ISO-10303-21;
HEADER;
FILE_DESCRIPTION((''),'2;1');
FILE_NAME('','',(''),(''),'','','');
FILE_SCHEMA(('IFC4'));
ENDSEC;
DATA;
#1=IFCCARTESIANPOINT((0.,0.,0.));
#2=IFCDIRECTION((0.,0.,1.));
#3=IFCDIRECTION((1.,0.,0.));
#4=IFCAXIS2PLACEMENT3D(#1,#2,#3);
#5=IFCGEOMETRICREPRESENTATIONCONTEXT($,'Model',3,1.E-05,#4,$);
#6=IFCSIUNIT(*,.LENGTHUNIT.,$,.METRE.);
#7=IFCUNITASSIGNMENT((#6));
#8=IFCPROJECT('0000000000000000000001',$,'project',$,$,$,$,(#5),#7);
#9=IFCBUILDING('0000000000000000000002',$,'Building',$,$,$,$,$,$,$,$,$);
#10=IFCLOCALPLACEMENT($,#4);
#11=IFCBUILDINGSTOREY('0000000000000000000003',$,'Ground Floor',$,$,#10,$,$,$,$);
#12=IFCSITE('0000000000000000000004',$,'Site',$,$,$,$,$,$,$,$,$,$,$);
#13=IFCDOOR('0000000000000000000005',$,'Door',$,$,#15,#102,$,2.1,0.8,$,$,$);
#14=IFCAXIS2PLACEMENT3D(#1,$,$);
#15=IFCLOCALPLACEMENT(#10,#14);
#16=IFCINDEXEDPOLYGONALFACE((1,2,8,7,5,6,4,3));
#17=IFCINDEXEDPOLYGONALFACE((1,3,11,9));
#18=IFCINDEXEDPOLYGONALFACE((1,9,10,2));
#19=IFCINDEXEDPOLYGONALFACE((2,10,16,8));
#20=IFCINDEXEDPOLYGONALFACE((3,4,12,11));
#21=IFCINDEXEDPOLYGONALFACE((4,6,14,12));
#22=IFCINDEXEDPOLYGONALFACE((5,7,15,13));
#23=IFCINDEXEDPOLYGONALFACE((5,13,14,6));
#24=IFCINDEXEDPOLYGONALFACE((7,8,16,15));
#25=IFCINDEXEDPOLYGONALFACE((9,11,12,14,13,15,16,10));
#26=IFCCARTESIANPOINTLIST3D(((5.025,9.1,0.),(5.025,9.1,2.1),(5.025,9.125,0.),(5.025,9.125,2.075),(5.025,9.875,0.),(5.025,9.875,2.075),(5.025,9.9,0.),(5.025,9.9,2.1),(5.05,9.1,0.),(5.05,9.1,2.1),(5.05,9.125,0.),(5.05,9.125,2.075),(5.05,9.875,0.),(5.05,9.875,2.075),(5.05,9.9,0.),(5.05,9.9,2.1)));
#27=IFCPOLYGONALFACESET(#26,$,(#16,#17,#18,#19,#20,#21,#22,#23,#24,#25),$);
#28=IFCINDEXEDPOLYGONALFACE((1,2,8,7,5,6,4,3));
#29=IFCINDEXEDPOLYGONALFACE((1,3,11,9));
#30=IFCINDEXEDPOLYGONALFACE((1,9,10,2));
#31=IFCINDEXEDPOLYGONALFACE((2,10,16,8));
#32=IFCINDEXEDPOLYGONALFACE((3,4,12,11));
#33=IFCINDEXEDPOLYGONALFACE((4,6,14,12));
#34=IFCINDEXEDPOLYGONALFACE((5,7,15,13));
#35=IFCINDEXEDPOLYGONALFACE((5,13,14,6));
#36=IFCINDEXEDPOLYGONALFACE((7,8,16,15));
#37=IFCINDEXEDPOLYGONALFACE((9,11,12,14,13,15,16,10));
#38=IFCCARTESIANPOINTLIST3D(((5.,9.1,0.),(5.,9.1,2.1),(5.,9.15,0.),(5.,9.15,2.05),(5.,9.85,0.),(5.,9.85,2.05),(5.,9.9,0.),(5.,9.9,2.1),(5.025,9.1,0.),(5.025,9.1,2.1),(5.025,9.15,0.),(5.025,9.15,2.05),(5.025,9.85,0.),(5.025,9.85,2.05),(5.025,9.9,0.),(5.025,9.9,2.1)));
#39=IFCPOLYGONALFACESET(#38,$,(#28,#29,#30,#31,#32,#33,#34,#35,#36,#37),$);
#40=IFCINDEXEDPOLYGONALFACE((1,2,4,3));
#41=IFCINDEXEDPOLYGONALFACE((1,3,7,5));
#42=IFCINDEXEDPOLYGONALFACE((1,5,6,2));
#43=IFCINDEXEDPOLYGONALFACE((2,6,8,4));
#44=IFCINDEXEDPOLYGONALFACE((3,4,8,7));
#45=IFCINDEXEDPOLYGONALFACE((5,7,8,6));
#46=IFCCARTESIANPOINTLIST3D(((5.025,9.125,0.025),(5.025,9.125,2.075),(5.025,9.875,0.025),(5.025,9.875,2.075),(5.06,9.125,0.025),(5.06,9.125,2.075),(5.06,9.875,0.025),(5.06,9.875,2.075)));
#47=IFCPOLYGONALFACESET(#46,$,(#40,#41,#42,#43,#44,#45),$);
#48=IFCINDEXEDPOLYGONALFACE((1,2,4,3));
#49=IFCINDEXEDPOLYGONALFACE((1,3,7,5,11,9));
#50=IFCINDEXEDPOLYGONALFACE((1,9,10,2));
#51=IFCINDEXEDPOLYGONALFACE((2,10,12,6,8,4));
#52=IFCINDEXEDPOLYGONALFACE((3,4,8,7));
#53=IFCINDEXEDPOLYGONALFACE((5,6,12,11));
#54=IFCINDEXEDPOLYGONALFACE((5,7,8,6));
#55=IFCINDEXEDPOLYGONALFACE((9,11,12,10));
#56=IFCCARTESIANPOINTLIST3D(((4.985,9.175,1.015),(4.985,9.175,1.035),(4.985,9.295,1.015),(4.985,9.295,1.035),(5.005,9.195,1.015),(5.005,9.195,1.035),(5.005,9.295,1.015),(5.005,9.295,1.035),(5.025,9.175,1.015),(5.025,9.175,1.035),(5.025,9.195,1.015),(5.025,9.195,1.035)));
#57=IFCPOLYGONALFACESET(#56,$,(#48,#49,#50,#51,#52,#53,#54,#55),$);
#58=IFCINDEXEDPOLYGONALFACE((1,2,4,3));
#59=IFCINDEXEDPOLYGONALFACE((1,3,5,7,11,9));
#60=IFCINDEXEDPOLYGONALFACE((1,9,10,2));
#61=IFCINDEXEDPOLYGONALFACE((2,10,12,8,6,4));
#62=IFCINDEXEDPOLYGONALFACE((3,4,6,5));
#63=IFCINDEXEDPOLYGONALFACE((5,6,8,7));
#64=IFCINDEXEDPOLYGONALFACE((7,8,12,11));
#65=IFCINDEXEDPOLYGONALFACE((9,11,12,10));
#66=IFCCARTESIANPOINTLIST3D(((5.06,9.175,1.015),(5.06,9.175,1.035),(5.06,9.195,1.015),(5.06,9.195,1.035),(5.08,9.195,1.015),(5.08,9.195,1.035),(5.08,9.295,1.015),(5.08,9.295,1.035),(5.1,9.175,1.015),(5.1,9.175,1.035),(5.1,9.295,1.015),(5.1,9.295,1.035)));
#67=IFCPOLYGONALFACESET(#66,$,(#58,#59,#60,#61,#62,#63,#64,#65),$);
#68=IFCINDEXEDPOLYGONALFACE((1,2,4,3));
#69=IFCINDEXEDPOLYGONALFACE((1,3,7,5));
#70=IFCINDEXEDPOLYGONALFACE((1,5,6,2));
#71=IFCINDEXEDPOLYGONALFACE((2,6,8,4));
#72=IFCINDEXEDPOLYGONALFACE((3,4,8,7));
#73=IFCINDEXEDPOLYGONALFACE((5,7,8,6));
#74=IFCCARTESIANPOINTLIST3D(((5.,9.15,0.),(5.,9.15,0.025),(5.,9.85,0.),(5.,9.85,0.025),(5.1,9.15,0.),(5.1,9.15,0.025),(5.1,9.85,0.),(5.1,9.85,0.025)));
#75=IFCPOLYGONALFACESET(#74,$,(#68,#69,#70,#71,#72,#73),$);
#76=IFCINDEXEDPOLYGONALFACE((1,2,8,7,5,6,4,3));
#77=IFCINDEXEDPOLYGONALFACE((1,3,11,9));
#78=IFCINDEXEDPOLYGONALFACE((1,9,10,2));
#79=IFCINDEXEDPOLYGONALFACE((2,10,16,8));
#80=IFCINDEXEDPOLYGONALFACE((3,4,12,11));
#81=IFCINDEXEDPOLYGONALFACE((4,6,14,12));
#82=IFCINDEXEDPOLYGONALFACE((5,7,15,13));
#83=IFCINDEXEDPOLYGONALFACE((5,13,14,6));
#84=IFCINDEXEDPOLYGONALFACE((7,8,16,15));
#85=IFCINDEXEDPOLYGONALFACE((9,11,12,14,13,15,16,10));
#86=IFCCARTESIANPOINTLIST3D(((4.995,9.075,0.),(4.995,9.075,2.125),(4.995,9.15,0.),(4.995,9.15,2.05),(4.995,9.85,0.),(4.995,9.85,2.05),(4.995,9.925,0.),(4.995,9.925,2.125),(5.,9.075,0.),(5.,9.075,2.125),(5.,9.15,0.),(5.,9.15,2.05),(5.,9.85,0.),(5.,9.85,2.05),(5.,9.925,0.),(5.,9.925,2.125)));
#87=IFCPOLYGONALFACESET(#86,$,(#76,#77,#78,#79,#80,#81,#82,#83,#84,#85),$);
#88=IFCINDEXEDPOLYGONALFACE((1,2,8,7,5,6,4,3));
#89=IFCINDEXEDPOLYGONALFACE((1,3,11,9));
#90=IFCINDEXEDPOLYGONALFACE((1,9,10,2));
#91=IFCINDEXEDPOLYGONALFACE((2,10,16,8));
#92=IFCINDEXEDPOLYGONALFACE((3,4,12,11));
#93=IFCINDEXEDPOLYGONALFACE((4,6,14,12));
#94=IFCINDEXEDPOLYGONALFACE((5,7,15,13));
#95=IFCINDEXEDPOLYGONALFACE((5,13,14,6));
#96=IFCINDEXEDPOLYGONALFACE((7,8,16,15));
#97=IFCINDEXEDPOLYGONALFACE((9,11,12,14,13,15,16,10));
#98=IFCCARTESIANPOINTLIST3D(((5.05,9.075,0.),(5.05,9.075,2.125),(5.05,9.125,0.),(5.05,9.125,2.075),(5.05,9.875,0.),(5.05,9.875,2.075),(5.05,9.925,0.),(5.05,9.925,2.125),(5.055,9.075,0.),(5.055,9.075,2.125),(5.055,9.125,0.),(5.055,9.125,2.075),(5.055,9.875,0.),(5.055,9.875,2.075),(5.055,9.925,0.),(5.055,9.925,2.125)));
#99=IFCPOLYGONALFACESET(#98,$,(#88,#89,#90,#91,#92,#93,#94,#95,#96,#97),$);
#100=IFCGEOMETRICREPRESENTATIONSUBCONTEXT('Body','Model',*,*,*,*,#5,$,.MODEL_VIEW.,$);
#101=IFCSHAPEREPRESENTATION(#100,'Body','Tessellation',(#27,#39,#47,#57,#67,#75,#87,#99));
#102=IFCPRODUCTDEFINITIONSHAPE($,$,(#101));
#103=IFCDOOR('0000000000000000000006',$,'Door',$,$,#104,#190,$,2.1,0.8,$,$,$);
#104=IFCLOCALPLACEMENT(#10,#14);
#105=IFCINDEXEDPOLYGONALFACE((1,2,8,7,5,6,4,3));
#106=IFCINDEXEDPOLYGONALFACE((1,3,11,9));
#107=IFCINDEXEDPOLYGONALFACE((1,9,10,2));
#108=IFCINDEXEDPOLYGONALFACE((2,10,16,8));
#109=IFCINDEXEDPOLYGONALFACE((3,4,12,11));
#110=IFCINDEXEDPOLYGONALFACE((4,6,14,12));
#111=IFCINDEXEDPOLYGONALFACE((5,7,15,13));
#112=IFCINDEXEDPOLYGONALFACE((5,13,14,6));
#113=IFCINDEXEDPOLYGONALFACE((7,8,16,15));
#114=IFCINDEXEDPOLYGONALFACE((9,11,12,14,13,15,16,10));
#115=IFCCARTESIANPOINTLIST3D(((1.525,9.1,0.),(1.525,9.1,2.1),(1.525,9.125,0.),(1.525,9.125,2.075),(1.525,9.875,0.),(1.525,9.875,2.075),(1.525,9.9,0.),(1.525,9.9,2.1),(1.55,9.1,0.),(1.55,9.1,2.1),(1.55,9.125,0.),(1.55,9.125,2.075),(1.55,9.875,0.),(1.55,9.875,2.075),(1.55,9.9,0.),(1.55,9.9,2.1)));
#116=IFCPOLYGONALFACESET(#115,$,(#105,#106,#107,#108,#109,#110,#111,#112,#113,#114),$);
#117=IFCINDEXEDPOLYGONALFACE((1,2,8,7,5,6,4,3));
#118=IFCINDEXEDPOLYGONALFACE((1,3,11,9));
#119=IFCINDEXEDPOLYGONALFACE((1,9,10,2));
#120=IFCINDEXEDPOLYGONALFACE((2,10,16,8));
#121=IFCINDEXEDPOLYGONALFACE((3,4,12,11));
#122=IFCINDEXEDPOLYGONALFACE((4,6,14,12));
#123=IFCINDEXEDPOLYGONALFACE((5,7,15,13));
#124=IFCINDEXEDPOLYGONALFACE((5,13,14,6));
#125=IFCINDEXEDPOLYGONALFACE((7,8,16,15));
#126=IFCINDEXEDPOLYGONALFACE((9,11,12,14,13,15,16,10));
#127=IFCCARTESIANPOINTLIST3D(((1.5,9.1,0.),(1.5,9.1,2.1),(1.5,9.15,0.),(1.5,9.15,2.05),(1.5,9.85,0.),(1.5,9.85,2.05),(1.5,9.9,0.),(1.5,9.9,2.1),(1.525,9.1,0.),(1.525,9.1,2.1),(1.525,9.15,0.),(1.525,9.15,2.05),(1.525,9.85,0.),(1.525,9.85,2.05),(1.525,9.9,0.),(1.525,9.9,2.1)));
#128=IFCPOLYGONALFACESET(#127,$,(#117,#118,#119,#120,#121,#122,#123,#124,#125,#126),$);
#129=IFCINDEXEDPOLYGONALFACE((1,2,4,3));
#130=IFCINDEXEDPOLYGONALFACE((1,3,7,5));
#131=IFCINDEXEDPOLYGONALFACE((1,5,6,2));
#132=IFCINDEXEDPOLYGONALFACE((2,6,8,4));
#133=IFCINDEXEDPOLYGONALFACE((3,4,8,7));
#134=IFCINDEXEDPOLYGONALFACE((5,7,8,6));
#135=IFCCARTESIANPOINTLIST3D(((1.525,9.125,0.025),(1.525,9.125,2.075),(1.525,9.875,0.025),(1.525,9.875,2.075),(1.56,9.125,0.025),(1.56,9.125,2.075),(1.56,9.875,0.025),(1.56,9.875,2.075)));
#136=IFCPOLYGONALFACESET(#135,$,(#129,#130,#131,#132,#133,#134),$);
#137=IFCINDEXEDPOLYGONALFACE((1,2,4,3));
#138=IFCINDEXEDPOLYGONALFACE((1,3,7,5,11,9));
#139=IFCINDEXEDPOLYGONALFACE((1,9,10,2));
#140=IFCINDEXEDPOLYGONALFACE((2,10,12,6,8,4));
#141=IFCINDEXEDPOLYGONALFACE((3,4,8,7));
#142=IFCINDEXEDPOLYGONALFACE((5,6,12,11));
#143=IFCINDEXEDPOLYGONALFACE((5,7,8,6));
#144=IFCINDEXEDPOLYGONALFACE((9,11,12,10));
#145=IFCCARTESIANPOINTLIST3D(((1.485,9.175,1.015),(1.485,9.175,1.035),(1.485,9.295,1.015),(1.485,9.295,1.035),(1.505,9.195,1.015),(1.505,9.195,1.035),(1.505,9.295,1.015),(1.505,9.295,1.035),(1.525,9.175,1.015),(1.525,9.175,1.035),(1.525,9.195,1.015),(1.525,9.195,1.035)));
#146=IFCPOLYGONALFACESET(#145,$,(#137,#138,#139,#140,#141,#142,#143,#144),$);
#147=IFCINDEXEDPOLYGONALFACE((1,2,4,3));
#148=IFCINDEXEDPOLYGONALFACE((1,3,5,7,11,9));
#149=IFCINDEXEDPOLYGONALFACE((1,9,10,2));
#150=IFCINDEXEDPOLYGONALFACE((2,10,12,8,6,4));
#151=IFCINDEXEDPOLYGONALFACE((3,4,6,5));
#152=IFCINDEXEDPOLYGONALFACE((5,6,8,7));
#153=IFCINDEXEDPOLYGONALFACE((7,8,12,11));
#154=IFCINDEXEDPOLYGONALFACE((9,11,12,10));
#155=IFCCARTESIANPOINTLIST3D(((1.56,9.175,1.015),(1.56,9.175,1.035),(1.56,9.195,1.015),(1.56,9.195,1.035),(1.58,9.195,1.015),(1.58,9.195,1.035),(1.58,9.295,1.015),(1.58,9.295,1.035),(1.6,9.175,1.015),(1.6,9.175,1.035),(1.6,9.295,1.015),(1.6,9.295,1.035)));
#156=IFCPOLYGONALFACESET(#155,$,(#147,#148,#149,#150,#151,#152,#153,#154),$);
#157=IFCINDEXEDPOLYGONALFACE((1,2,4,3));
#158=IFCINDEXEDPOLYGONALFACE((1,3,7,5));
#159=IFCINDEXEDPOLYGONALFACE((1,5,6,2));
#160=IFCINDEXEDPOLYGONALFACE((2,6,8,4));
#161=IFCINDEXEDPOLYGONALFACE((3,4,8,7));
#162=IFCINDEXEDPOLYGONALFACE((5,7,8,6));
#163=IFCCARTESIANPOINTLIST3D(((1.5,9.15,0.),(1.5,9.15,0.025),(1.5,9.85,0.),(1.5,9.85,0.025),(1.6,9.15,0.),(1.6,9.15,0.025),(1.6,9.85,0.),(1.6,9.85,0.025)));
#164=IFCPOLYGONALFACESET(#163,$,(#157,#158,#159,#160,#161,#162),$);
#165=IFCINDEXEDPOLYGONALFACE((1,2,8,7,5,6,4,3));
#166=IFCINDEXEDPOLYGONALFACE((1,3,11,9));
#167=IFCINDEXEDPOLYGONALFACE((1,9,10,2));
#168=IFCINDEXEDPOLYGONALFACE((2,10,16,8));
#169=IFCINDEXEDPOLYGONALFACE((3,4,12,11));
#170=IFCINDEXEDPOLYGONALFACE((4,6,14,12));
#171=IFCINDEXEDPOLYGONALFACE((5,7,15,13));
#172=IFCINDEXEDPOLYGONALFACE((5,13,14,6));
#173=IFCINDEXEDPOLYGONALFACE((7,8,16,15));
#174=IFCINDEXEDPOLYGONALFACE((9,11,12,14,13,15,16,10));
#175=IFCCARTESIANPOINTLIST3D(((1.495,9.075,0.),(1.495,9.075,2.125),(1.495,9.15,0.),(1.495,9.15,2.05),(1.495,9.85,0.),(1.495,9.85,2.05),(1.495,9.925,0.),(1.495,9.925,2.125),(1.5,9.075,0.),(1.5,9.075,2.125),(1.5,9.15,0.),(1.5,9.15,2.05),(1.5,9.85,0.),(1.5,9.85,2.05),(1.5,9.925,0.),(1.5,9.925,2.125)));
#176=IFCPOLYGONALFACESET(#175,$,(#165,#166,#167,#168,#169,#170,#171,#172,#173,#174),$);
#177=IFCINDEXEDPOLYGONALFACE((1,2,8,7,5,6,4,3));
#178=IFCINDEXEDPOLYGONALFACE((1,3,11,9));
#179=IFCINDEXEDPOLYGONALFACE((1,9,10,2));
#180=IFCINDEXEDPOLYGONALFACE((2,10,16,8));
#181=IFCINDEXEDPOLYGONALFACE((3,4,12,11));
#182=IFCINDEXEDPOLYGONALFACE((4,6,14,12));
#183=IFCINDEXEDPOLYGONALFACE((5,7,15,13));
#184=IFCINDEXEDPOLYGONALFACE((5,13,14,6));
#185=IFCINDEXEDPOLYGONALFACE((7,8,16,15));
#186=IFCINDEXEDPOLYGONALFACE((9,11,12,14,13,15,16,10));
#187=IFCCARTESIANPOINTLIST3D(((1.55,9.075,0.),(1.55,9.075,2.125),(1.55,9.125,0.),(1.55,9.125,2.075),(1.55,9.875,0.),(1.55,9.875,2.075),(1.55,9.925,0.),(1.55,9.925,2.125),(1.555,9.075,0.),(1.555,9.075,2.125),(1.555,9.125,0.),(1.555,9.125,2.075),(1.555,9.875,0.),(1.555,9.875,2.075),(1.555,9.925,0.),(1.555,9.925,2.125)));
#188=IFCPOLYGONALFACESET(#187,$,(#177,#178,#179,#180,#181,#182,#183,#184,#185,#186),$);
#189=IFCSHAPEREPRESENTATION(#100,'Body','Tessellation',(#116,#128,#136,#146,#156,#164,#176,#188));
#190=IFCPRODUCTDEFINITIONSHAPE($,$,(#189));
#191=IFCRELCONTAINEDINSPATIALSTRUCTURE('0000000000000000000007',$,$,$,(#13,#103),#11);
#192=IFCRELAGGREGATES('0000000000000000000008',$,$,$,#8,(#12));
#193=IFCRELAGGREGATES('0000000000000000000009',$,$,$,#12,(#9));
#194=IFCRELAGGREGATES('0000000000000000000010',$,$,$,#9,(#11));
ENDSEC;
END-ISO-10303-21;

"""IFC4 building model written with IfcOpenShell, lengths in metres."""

from ifc_helpers import new_model, si_unit, frame, origin_with_axes, place, context, subcontext, project, spatial, line, indexed_curve, outline, extrude, element, save


model = new_model("IFC4")

# Units and contexts
model_context = context("Model", 3, precision=1e-05, world=origin_with_axes())
body_context = subcontext(model_context, "Body", "Model", "MODEL_VIEW")
ifc_project = project(units=[si_unit("LENGTHUNIT", "METRE")], contexts=[model_context])

# Site, building, storey
site = spatial("IfcSite", under=ifc_project, Name="Site")
building = spatial("IfcBuilding", under=site, Name="Building")
storey_placement = place(None, origin_with_axes())
storey = spatial("IfcBuildingStorey", under=building, at=storey_placement, Name="Ground Floor")

# Doors
door_1_placement = place(storey_placement, frame((5.0, 9.9, 0.0), z_axis=(0.0, 0.0, 1.0), x_axis=(0.0, -1.0, 0.0)))
element("IfcDoor", 1, at=door_1_placement, inside=storey, Name="Door", OverallHeight=2.1, OverallWidth=0.8, context=body_context, shape_type="SweptSolid", body=[
    extrude(outline(indexed_curve([(0.0, 0.0), (0.0, 2.1), (0.8, 2.1), (0.8, 0.0), (0.775, 0.0), (0.775, 2.075), (0.025, 2.075), (0.025, 0.0)], segments=[line(1, 2, 3, 4, 5, 6, 7, 8, 1)])), frame((0.0, 0.025, 0.0), z_axis=(0.0, -1.0, 0.0), x_axis=(1.0, 0.0, 0.0)), (0.0, 0.0, -1.0), 0.025),
    extrude(outline(indexed_curve([(0.0, 0.0), (0.0, 2.1), (0.8, 2.1), (0.8, 0.0), (0.75, 0.0), (0.75, 2.05), (0.05, 2.05), (0.05, 0.0)], segments=[line(1, 2, 3, 4, 5, 6, 7, 8, 1)])), frame((0.0, 0.0, 0.0), z_axis=(0.0, -1.0, 0.0), x_axis=(1.0, 0.0, 0.0)), (0.0, 0.0, -1.0), 0.025),
    extrude(outline(indexed_curve([(0.0, 0.0), (0.75, 0.0), (0.75, 0.035), (0.0, 0.035)], segments=[line(1, 2, 3, 4, 1)])), frame((0.025, 0.025, 0.025), z_axis=(0.0, 0.0, 1.0), x_axis=(1.0, 0.0, 0.0)), (0.0, 0.0, 1.0), 2.05),
    extrude(outline(indexed_curve([(0.0, 0.0), (0.0, -0.04), (-0.12, -0.04), (-0.12, -0.02), (-0.02, -0.02), (-0.02, 0.0)], segments=[line(1, 2, 3, 4, 5, 6, 1)])), frame((0.725, 0.025, 1.015), z_axis=(0.0, 0.0, 1.0), x_axis=(1.0, 0.0, 0.0)), (0.0, 0.0, 1.0), 0.02),
    extrude(outline(indexed_curve([(0.0, 0.0), (0.0, 0.04), (-0.12, 0.04), (-0.12, 0.02), (-0.02, 0.02), (-0.02, 0.0)], segments=[line(1, 2, 3, 4, 5, 6, 1)])), frame((0.725, 0.06, 1.015), z_axis=(0.0, 0.0, 1.0), x_axis=(1.0, 0.0, 0.0)), (0.0, 0.0, 1.0), 0.02),
    extrude(outline(indexed_curve([(0.0, 0.0), (0.7, 0.0), (0.7, 0.1), (0.0, 0.1)], segments=[line(1, 2, 3, 4, 1)])), frame((0.05, 0.0, 0.0), z_axis=(0.0, 0.0, 1.0), x_axis=(1.0, 0.0, 0.0)), (0.0, 0.0, 1.0), 0.025),
    extrude(outline(indexed_curve([(0.0, 0.0), (0.0, 2.125), (0.85, 2.125), (0.85, 0.0), (0.775, 0.0), (0.775, 2.05), (0.075, 2.05), (0.075, 0.0)], segments=[line(1, 2, 3, 4, 5, 6, 7, 8, 1)])), frame((-0.025, -0.005, 0.0), z_axis=(0.0, -1.0, 0.0), x_axis=(1.0, 0.0, 0.0)), (0.0, 0.0, -1.0), 0.005),
    extrude(outline(indexed_curve([(0.0, 0.0), (0.0, 2.125), (0.85, 2.125), (0.85, 0.0), (0.8, 0.0), (0.8, 2.075), (0.05, 2.075), (0.05, 0.0)], segments=[line(1, 2, 3, 4, 5, 6, 7, 8, 1)])), frame((-0.025, 0.05, 0.0), z_axis=(0.0, -1.0, 0.0), x_axis=(1.0, 0.0, 0.0)), (0.0, 0.0, -1.0), 0.005),
])
door_2_placement = place(storey_placement, frame((1.5, 9.9, 0.0), z_axis=(0.0, 0.0, 1.0), x_axis=(0.0, -1.0, 0.0)))
element("IfcDoor", 2, at=door_2_placement, inside=storey, Name="Door", OverallHeight=2.1, OverallWidth=0.8, context=body_context, shape_type="SweptSolid", body=[
    extrude(outline(indexed_curve([(0.0, 0.0), (0.0, 2.1), (0.8, 2.1), (0.8, 0.0), (0.775, 0.0), (0.775, 2.075), (0.025, 2.075), (0.025, 0.0)], segments=[line(1, 2, 3, 4, 5, 6, 7, 8, 1)])), frame((0.0, 0.025, 0.0), z_axis=(0.0, -1.0, 0.0), x_axis=(1.0, 0.0, 0.0)), (0.0, 0.0, -1.0), 0.025),
    extrude(outline(indexed_curve([(0.0, 0.0), (0.0, 2.1), (0.8, 2.1), (0.8, 0.0), (0.75, 0.0), (0.75, 2.05), (0.05, 2.05), (0.05, 0.0)], segments=[line(1, 2, 3, 4, 5, 6, 7, 8, 1)])), frame((0.0, 0.0, 0.0), z_axis=(0.0, -1.0, 0.0), x_axis=(1.0, 0.0, 0.0)), (0.0, 0.0, -1.0), 0.025),
    extrude(outline(indexed_curve([(0.0, 0.0), (0.75, 0.0), (0.75, 0.035), (0.0, 0.035)], segments=[line(1, 2, 3, 4, 1)])), frame((0.025, 0.025, 0.025), z_axis=(0.0, 0.0, 1.0), x_axis=(1.0, 0.0, 0.0)), (0.0, 0.0, 1.0), 2.05),
    extrude(outline(indexed_curve([(0.0, 0.0), (0.0, -0.04), (-0.12, -0.04), (-0.12, -0.02), (-0.02, -0.02), (-0.02, 0.0)], segments=[line(1, 2, 3, 4, 5, 6, 1)])), frame((0.725, 0.025, 1.015), z_axis=(0.0, 0.0, 1.0), x_axis=(1.0, 0.0, 0.0)), (0.0, 0.0, 1.0), 0.02),
    extrude(outline(indexed_curve([(0.0, 0.0), (0.0, 0.04), (-0.12, 0.04), (-0.12, 0.02), (-0.02, 0.02), (-0.02, 0.0)], segments=[line(1, 2, 3, 4, 5, 6, 1)])), frame((0.725, 0.06, 1.015), z_axis=(0.0, 0.0, 1.0), x_axis=(1.0, 0.0, 0.0)), (0.0, 0.0, 1.0), 0.02),
    extrude(outline(indexed_curve([(0.0, 0.0), (0.7, 0.0), (0.7, 0.1), (0.0, 0.1)], segments=[line(1, 2, 3, 4, 1)])), frame((0.05, 0.0, 0.0), z_axis=(0.0, 0.0, 1.0), x_axis=(1.0, 0.0, 0.0)), (0.0, 0.0, 1.0), 0.025),
    extrude(outline(indexed_curve([(0.0, 0.0), (0.0, 2.125), (0.85, 2.125), (0.85, 0.0), (0.775, 0.0), (0.775, 2.05), (0.075, 2.05), (0.075, 0.0)], segments=[line(1, 2, 3, 4, 5, 6, 7, 8, 1)])), frame((-0.025, -0.005, 0.0), z_axis=(0.0, -1.0, 0.0), x_axis=(1.0, 0.0, 0.0)), (0.0, 0.0, -1.0), 0.005),
    extrude(outline(indexed_curve([(0.0, 0.0), (0.0, 2.125), (0.85, 2.125), (0.85, 0.0), (0.8, 0.0), (0.8, 2.075), (0.05, 2.075), (0.05, 0.0)], segments=[line(1, 2, 3, 4, 5, 6, 7, 8, 1)])), frame((-0.025, 0.05, 0.0), z_axis=(0.0, -1.0, 0.0), x_axis=(1.0, 0.0, 0.0)), (0.0, 0.0, -1.0), 0.005),
])

save(model, "model.ifc")
